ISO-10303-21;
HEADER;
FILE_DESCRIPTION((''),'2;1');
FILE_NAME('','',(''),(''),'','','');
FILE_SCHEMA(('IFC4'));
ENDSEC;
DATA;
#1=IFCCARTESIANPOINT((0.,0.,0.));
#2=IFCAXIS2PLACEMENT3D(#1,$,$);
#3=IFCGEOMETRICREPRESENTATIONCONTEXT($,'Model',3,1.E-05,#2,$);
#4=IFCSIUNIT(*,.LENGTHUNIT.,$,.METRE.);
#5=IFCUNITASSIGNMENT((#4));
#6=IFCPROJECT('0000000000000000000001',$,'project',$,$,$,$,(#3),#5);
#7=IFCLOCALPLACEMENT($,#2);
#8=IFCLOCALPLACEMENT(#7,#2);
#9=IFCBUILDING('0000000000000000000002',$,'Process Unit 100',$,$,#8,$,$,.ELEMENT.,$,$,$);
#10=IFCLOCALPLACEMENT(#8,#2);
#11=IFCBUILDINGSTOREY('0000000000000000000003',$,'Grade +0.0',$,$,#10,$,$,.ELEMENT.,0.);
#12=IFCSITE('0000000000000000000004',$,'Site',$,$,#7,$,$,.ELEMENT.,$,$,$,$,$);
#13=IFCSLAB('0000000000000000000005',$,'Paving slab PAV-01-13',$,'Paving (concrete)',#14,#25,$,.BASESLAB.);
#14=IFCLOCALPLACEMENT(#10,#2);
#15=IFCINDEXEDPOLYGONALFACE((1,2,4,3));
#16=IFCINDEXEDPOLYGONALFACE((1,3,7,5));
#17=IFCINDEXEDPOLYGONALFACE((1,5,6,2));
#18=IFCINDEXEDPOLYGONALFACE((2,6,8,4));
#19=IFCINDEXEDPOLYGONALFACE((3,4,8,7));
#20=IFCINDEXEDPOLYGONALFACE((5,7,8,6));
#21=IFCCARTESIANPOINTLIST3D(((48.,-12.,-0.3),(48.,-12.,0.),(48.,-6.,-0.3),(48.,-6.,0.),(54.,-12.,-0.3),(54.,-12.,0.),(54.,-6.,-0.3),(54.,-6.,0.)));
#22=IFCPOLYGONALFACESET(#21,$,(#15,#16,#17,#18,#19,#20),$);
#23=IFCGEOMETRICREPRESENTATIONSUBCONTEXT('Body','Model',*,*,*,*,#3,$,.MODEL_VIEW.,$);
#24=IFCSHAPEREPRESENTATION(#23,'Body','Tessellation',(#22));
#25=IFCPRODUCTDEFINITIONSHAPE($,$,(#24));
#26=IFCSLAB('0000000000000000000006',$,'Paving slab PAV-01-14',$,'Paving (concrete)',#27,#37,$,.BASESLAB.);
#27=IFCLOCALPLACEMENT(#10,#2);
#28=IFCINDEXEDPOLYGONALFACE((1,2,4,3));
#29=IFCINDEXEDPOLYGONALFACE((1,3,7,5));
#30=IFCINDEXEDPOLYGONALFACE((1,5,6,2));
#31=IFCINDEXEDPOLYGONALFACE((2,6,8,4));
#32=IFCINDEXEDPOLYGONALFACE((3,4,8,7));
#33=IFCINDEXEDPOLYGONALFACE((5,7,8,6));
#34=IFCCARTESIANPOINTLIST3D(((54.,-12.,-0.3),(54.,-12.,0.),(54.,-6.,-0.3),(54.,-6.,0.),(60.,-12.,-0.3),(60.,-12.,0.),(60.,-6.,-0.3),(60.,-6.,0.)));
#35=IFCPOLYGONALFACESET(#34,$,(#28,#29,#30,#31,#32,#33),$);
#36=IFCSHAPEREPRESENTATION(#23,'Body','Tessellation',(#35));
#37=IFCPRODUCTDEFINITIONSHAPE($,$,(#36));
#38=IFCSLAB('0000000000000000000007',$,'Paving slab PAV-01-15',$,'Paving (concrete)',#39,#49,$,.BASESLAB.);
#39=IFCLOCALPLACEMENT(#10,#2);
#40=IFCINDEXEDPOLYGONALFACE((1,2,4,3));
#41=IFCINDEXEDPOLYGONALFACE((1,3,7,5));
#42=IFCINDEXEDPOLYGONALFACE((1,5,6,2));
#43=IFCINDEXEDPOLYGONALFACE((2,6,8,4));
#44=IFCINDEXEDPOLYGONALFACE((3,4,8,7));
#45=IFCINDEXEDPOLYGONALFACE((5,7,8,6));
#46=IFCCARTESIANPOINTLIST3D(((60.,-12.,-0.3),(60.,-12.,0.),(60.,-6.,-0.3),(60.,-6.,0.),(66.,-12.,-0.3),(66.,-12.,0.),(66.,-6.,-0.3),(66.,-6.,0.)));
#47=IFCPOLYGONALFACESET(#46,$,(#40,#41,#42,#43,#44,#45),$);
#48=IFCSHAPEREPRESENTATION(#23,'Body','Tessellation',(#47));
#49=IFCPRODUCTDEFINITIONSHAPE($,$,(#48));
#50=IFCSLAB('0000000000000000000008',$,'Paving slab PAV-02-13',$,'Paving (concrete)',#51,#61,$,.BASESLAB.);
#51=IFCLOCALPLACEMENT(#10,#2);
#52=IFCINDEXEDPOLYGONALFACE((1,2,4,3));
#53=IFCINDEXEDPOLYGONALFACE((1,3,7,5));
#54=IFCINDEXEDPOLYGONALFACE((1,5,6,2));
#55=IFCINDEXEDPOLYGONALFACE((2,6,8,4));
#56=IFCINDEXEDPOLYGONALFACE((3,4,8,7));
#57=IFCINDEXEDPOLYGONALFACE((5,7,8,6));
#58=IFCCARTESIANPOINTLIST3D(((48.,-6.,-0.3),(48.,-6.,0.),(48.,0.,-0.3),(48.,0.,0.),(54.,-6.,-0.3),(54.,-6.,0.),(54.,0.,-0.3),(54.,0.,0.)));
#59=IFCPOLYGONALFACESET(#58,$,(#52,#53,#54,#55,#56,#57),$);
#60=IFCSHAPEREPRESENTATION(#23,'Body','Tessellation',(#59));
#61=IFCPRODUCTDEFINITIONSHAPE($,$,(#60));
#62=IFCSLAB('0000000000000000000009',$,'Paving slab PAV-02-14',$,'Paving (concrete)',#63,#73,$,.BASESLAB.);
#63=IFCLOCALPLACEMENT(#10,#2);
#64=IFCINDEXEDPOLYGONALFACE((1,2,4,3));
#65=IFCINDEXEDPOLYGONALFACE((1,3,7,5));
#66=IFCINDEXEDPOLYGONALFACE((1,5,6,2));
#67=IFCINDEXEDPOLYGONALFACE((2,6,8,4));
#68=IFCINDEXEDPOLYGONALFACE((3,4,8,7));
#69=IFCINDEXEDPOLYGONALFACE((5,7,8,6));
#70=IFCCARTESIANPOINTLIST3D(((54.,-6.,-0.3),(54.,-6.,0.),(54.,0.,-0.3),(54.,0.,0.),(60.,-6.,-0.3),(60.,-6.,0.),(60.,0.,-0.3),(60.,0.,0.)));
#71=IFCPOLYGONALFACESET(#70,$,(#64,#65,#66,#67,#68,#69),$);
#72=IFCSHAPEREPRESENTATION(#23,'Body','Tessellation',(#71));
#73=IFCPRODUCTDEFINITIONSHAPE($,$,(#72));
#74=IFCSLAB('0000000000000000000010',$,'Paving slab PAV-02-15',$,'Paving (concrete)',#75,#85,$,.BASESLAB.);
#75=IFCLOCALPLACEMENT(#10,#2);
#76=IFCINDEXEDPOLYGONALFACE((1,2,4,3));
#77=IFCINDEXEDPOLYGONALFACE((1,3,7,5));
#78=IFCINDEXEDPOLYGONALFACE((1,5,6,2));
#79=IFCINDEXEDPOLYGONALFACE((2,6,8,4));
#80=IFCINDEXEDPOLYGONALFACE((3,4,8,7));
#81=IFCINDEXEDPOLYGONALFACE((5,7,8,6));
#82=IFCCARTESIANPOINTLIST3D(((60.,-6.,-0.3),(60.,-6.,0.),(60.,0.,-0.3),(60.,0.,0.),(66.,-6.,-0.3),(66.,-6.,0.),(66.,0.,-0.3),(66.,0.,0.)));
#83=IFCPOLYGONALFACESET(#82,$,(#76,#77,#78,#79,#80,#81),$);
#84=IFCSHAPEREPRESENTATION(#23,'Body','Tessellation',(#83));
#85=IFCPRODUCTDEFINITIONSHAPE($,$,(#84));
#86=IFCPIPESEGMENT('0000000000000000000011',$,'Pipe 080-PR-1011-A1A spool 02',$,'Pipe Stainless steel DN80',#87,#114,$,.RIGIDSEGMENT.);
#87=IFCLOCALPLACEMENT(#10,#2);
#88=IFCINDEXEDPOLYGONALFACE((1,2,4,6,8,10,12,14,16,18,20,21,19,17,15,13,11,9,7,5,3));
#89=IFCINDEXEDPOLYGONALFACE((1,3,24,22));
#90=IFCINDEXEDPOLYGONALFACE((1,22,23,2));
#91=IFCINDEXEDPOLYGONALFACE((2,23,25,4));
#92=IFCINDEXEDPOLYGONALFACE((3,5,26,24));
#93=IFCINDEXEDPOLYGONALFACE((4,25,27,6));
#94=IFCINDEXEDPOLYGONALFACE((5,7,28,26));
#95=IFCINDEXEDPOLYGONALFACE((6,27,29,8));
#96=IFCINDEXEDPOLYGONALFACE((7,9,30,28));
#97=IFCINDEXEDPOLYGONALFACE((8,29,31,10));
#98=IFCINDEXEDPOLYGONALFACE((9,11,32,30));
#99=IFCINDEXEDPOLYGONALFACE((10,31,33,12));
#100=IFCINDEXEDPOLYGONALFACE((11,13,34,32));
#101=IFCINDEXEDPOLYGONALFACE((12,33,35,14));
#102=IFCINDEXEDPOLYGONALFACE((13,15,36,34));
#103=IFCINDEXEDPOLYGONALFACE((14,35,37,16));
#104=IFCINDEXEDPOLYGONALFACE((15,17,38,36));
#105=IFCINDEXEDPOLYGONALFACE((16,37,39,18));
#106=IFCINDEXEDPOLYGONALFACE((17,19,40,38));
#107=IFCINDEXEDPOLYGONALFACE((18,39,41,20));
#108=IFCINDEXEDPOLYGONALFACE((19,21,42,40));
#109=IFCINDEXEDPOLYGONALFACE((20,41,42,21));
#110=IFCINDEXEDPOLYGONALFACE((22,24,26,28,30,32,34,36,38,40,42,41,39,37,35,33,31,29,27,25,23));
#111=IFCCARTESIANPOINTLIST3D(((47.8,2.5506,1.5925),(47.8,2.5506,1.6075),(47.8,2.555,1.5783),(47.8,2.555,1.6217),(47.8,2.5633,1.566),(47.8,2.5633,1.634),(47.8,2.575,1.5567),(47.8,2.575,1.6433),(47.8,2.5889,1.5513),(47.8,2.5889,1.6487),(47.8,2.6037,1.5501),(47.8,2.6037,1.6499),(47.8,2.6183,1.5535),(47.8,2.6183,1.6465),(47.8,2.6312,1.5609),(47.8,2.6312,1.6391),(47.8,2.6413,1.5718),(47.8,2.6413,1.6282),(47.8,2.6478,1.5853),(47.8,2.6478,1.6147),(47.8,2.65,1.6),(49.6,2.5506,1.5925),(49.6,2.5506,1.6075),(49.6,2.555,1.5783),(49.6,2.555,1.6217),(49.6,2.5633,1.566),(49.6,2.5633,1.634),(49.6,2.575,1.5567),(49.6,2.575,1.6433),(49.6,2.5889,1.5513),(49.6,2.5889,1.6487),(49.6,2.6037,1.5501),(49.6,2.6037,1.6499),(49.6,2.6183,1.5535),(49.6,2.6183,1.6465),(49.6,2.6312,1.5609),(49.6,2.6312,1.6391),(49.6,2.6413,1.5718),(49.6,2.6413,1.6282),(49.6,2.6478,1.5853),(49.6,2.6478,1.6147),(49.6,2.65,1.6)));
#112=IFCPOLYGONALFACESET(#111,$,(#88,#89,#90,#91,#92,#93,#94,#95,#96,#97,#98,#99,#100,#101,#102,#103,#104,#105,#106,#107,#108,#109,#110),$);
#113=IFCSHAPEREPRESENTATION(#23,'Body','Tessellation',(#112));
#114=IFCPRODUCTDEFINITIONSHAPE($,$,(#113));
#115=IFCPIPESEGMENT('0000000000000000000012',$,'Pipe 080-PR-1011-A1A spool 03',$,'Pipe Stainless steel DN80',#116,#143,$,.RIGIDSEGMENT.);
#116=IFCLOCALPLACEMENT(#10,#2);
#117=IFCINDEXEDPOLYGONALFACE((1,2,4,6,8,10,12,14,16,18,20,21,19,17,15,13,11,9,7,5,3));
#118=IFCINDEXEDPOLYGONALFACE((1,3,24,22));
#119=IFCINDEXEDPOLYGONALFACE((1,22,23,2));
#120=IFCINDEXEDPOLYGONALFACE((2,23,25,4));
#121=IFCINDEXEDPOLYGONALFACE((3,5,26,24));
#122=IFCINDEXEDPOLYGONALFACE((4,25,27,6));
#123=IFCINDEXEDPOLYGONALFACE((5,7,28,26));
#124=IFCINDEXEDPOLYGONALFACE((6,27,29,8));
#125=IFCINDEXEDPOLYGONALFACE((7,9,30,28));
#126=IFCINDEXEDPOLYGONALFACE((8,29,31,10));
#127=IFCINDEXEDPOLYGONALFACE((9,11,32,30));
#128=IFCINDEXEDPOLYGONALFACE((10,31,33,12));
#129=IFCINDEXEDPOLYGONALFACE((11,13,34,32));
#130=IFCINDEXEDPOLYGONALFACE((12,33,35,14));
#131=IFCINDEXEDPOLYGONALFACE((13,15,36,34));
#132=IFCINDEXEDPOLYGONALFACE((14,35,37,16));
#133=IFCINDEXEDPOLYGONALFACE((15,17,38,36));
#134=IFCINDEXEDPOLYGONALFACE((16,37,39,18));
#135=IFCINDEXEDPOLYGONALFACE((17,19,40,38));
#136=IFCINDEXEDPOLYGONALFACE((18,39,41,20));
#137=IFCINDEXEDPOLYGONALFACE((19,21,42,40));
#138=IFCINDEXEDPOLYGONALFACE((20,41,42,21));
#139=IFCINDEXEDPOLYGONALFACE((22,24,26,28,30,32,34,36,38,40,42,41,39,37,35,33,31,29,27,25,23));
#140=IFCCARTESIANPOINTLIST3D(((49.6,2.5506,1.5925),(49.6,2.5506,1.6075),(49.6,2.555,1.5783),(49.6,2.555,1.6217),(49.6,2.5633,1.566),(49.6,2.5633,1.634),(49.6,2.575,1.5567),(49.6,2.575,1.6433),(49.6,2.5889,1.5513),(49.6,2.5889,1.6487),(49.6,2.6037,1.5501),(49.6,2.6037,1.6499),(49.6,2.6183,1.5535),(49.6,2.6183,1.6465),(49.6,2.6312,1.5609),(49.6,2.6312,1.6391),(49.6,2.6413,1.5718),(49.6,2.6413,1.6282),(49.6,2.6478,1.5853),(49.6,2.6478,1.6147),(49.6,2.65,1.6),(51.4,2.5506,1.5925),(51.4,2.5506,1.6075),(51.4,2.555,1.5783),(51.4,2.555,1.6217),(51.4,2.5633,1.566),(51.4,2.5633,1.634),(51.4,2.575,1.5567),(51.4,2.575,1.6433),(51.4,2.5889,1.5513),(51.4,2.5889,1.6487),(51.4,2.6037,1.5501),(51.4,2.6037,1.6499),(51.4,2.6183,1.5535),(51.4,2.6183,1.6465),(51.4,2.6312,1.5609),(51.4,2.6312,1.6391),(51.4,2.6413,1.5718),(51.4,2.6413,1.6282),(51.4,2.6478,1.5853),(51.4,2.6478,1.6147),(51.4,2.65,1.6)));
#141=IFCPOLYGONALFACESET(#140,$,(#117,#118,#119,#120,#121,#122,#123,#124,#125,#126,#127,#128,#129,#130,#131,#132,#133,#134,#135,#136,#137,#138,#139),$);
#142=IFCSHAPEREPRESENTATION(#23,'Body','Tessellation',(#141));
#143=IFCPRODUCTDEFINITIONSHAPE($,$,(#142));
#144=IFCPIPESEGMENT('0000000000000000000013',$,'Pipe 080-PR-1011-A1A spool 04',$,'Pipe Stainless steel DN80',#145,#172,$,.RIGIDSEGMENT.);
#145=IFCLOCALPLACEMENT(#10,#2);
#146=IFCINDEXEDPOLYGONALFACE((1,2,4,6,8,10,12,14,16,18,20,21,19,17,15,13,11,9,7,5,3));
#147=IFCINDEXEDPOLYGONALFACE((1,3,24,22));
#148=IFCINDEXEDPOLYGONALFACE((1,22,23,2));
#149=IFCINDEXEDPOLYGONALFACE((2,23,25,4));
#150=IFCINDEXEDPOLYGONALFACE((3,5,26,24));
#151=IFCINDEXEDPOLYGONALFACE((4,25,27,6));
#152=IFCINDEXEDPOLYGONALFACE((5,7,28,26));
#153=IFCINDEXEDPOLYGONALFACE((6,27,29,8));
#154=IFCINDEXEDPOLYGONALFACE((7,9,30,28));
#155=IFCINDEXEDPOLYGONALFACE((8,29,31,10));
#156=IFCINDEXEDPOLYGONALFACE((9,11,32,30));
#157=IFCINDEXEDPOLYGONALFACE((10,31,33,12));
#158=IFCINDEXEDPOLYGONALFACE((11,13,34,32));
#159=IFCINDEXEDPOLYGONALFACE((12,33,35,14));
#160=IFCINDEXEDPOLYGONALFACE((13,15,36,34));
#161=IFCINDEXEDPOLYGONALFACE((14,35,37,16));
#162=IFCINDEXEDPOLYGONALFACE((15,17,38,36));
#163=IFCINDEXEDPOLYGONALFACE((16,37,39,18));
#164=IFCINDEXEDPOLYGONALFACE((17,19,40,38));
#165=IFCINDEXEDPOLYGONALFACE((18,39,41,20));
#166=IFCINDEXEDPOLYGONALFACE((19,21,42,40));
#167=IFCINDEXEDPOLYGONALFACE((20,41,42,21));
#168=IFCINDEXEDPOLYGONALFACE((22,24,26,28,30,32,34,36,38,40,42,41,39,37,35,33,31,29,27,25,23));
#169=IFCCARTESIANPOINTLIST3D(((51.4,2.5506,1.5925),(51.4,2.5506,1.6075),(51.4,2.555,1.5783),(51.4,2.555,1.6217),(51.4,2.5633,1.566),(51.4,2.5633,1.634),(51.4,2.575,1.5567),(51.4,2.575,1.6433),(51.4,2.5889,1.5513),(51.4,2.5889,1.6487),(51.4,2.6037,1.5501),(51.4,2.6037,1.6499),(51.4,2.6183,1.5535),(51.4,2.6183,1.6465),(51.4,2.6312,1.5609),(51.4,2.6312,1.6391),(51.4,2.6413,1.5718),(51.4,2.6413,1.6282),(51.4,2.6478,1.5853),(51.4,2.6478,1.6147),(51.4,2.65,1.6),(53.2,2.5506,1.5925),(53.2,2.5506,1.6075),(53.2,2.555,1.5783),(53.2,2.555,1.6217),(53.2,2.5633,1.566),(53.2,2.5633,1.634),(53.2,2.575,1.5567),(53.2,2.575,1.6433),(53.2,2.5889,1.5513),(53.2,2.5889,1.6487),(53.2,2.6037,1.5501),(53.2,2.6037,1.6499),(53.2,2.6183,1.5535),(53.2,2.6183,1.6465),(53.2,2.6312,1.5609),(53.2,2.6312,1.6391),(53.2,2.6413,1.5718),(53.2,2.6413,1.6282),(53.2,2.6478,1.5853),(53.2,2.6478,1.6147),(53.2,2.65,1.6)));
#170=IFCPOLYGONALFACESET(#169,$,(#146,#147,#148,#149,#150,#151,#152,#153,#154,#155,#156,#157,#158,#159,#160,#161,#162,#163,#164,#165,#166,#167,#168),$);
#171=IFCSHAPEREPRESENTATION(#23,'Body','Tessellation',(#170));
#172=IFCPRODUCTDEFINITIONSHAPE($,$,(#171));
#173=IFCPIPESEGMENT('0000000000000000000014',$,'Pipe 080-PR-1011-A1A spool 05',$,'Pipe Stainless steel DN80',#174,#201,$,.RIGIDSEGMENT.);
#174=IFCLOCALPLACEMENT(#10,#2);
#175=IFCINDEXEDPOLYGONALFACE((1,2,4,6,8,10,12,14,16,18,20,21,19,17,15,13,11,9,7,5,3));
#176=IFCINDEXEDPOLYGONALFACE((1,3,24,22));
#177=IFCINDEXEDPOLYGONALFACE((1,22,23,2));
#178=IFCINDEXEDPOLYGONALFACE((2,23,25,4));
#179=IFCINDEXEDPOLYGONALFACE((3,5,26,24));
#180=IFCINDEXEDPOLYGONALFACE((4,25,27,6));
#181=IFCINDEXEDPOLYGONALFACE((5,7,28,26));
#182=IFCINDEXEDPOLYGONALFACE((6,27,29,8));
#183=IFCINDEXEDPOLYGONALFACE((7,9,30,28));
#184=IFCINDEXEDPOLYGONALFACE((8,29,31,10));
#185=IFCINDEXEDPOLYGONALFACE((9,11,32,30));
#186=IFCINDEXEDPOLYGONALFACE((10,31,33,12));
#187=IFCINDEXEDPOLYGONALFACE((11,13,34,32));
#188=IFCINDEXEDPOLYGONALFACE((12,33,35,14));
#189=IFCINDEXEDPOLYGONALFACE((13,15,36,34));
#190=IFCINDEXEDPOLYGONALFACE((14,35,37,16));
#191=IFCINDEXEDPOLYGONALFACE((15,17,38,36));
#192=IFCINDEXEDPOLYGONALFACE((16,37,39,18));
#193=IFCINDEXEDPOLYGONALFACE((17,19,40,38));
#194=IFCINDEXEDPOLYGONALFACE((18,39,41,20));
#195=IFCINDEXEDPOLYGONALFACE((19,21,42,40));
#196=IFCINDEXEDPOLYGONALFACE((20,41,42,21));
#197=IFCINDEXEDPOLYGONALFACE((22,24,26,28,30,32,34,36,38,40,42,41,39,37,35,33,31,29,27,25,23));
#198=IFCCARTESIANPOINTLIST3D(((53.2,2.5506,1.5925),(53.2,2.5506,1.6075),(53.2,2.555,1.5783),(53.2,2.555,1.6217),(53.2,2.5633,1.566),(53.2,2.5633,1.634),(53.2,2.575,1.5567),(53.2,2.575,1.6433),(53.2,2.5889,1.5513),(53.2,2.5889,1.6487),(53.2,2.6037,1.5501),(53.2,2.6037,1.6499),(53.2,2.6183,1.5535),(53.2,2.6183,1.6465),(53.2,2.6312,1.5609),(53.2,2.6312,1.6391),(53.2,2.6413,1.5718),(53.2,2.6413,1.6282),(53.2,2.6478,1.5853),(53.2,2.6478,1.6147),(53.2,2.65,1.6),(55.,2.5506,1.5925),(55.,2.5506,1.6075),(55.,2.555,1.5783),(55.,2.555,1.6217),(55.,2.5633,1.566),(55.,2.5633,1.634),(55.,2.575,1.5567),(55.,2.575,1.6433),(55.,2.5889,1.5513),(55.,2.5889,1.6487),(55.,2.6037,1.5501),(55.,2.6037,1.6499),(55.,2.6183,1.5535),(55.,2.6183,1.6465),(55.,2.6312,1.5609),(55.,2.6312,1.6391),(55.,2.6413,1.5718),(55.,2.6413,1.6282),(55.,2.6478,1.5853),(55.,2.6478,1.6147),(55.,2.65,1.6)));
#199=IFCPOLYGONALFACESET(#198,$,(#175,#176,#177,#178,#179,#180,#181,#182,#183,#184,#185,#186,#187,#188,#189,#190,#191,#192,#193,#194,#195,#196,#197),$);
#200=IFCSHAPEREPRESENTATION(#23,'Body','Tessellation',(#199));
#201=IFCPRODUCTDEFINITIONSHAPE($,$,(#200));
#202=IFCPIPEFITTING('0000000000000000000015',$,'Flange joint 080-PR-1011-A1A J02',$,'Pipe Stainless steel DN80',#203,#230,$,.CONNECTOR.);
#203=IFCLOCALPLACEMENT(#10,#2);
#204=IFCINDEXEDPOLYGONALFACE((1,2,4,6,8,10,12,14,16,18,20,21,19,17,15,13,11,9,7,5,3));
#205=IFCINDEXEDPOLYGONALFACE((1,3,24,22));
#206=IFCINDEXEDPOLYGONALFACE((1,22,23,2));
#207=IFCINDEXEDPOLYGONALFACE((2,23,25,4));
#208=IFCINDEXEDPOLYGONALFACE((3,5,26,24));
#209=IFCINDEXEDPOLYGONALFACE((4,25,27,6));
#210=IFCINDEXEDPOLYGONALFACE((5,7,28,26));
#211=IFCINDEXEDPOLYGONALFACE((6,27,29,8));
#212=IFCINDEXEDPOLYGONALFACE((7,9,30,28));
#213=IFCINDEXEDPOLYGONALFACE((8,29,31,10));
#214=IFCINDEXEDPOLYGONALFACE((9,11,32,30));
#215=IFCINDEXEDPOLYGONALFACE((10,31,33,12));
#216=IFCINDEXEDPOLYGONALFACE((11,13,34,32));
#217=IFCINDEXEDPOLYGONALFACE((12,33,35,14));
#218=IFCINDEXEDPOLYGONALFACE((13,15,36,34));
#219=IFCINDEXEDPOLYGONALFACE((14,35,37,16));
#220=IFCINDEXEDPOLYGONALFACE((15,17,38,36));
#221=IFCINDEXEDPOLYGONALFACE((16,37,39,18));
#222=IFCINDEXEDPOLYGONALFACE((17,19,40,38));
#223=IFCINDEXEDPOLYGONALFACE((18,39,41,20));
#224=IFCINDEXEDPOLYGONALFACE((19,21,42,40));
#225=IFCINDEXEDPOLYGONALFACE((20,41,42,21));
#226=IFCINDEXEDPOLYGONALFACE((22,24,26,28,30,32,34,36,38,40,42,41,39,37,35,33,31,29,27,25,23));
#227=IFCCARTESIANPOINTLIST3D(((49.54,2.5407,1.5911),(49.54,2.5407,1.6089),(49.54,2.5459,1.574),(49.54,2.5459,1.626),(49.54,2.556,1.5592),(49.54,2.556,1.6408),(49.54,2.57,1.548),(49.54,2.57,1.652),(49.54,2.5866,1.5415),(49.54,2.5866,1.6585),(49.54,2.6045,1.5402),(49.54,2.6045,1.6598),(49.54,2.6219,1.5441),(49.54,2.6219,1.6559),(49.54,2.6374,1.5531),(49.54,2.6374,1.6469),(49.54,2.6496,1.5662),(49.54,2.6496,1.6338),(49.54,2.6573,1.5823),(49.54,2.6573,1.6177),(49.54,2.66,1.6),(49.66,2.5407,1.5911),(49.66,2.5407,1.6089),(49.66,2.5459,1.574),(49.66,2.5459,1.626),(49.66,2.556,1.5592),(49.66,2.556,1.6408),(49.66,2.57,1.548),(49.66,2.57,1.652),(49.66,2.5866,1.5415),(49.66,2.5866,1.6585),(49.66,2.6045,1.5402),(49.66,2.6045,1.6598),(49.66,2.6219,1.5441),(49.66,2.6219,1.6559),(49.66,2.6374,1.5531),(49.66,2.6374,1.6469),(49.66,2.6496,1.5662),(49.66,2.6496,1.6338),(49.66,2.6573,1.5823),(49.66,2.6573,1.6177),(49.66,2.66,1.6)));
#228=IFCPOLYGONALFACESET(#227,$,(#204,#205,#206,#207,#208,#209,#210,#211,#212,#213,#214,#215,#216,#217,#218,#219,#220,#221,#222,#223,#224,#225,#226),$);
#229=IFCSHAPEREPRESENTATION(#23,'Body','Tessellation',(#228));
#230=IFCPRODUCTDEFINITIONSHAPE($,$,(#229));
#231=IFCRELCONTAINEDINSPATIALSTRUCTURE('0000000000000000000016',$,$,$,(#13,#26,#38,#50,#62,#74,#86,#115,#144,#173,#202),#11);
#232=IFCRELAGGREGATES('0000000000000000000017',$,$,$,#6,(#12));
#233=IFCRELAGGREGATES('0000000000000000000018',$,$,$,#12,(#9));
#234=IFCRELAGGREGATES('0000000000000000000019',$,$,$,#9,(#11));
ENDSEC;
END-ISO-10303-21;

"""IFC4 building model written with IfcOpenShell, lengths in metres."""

from ifc_helpers import new_model, si_unit, frame, origin, place, context, subcontext, project, spatial, rectangle, circle, extrude, element, save


model = new_model("IFC4")

# Units and contexts
model_context = context("Model", 3, precision=1e-05, world=origin())
body_context = subcontext(model_context, "Body", "Model", "MODEL_VIEW")
ifc_project = project(units=[si_unit("LENGTHUNIT", "METRE")], contexts=[model_context])

# Site, building, storey
site_placement = place(None, origin())
site = spatial("IfcSite", under=ifc_project, at=site_placement, Name="Site", CompositionType="ELEMENT")
building_placement = place(site_placement, origin())
building = spatial("IfcBuilding", under=site, at=building_placement, Name="Process Unit 100", CompositionType="ELEMENT")
storey_placement = place(building_placement, origin())
storey = spatial("IfcBuildingStorey", under=building, at=storey_placement, Name="Grade +0.0", CompositionType="ELEMENT", Elevation=0.0)

# Slabs
for number, where, z_axis, x_axis, name in (
    (1, (51.0, -9.0, -0.3), (0.0, 0.0, 1.0), (1.0, 0.0, 0.0), "Paving slab PAV-01-13"),
    (2, (57.0, -9.0, -0.3), (0.0, 0.0, 1.0), (1.0, 0.0, 0.0), "Paving slab PAV-01-14"),
    (3, (63.0, -9.0, -0.3), (0.0, 0.0, 1.0), (1.0, 0.0, 0.0), "Paving slab PAV-01-15"),
    (4, (51.0, -3.0, -0.3), (0.0, 0.0, 1.0), (1.0, 0.0, 0.0), "Paving slab PAV-02-13"),
    (5, (57.0, -3.0, -0.3), (0.0, 0.0, 1.0), (1.0, 0.0, 0.0), "Paving slab PAV-02-14"),
    (6, (63.0, -3.0, -0.3), (0.0, 0.0, 1.0), (1.0, 0.0, 0.0), "Paving slab PAV-02-15"),
):
    element("IfcSlab", number, at=place(storey_placement, frame(where, z_axis=z_axis, x_axis=x_axis)), inside=storey, Name=name, ObjectType="Paving (concrete)", PredefinedType="BASESLAB", context=body_context, shape_type="SweptSolid", body=[
        extrude(rectangle(XDim=6.0, YDim=6.0), origin(), (0.0, 0.0, 1.0), 0.3),
    ])

# Pipe segments
for number, where, z_axis, x_axis, name in (
    (7, (47.8, 2.6, 1.6), (1.0, 0.0, 0.0), (0.0, 1.0, 0.0), "Pipe 080-PR-1011-A1A spool 02"),
    (8, (49.6, 2.6, 1.6), (1.0, 0.0, 0.0), (0.0, 1.0, 0.0), "Pipe 080-PR-1011-A1A spool 03"),
    (9, (51.4, 2.6, 1.6), (1.0, 0.0, 0.0), (0.0, 1.0, 0.0), "Pipe 080-PR-1011-A1A spool 04"),
    (10, (53.2, 2.6, 1.6), (1.0, 0.0, 0.0), (0.0, 1.0, 0.0), "Pipe 080-PR-1011-A1A spool 05"),
):
    element("IfcPipeSegment", number, at=place(storey_placement, frame(where, z_axis=z_axis, x_axis=x_axis)), inside=storey, Name=name, ObjectType="Pipe Stainless steel DN80", PredefinedType="RIGIDSEGMENT", context=body_context, shape_type="SweptSolid", body=[
        extrude(circle(Radius=0.05), origin(), (0.0, 0.0, 1.0), 1.8),
    ])

# Pipe fitting
for number, where, z_axis, x_axis, name in (
    (11, (49.54, 2.6, 1.6), (1.0, 0.0, 0.0), (0.0, 1.0, 0.0), "Flange joint 080-PR-1011-A1A J02"),
):
    element("IfcPipeFitting", number, at=place(storey_placement, frame(where, z_axis=z_axis, x_axis=x_axis)), inside=storey, Name=name, ObjectType="Pipe Stainless steel DN80", PredefinedType="CONNECTOR", context=body_context, shape_type="SweptSolid", body=[
        extrude(circle(Radius=0.06), origin(), (0.0, 0.0, 1.0), 0.12),
    ])

save(model, "model.ifc")
